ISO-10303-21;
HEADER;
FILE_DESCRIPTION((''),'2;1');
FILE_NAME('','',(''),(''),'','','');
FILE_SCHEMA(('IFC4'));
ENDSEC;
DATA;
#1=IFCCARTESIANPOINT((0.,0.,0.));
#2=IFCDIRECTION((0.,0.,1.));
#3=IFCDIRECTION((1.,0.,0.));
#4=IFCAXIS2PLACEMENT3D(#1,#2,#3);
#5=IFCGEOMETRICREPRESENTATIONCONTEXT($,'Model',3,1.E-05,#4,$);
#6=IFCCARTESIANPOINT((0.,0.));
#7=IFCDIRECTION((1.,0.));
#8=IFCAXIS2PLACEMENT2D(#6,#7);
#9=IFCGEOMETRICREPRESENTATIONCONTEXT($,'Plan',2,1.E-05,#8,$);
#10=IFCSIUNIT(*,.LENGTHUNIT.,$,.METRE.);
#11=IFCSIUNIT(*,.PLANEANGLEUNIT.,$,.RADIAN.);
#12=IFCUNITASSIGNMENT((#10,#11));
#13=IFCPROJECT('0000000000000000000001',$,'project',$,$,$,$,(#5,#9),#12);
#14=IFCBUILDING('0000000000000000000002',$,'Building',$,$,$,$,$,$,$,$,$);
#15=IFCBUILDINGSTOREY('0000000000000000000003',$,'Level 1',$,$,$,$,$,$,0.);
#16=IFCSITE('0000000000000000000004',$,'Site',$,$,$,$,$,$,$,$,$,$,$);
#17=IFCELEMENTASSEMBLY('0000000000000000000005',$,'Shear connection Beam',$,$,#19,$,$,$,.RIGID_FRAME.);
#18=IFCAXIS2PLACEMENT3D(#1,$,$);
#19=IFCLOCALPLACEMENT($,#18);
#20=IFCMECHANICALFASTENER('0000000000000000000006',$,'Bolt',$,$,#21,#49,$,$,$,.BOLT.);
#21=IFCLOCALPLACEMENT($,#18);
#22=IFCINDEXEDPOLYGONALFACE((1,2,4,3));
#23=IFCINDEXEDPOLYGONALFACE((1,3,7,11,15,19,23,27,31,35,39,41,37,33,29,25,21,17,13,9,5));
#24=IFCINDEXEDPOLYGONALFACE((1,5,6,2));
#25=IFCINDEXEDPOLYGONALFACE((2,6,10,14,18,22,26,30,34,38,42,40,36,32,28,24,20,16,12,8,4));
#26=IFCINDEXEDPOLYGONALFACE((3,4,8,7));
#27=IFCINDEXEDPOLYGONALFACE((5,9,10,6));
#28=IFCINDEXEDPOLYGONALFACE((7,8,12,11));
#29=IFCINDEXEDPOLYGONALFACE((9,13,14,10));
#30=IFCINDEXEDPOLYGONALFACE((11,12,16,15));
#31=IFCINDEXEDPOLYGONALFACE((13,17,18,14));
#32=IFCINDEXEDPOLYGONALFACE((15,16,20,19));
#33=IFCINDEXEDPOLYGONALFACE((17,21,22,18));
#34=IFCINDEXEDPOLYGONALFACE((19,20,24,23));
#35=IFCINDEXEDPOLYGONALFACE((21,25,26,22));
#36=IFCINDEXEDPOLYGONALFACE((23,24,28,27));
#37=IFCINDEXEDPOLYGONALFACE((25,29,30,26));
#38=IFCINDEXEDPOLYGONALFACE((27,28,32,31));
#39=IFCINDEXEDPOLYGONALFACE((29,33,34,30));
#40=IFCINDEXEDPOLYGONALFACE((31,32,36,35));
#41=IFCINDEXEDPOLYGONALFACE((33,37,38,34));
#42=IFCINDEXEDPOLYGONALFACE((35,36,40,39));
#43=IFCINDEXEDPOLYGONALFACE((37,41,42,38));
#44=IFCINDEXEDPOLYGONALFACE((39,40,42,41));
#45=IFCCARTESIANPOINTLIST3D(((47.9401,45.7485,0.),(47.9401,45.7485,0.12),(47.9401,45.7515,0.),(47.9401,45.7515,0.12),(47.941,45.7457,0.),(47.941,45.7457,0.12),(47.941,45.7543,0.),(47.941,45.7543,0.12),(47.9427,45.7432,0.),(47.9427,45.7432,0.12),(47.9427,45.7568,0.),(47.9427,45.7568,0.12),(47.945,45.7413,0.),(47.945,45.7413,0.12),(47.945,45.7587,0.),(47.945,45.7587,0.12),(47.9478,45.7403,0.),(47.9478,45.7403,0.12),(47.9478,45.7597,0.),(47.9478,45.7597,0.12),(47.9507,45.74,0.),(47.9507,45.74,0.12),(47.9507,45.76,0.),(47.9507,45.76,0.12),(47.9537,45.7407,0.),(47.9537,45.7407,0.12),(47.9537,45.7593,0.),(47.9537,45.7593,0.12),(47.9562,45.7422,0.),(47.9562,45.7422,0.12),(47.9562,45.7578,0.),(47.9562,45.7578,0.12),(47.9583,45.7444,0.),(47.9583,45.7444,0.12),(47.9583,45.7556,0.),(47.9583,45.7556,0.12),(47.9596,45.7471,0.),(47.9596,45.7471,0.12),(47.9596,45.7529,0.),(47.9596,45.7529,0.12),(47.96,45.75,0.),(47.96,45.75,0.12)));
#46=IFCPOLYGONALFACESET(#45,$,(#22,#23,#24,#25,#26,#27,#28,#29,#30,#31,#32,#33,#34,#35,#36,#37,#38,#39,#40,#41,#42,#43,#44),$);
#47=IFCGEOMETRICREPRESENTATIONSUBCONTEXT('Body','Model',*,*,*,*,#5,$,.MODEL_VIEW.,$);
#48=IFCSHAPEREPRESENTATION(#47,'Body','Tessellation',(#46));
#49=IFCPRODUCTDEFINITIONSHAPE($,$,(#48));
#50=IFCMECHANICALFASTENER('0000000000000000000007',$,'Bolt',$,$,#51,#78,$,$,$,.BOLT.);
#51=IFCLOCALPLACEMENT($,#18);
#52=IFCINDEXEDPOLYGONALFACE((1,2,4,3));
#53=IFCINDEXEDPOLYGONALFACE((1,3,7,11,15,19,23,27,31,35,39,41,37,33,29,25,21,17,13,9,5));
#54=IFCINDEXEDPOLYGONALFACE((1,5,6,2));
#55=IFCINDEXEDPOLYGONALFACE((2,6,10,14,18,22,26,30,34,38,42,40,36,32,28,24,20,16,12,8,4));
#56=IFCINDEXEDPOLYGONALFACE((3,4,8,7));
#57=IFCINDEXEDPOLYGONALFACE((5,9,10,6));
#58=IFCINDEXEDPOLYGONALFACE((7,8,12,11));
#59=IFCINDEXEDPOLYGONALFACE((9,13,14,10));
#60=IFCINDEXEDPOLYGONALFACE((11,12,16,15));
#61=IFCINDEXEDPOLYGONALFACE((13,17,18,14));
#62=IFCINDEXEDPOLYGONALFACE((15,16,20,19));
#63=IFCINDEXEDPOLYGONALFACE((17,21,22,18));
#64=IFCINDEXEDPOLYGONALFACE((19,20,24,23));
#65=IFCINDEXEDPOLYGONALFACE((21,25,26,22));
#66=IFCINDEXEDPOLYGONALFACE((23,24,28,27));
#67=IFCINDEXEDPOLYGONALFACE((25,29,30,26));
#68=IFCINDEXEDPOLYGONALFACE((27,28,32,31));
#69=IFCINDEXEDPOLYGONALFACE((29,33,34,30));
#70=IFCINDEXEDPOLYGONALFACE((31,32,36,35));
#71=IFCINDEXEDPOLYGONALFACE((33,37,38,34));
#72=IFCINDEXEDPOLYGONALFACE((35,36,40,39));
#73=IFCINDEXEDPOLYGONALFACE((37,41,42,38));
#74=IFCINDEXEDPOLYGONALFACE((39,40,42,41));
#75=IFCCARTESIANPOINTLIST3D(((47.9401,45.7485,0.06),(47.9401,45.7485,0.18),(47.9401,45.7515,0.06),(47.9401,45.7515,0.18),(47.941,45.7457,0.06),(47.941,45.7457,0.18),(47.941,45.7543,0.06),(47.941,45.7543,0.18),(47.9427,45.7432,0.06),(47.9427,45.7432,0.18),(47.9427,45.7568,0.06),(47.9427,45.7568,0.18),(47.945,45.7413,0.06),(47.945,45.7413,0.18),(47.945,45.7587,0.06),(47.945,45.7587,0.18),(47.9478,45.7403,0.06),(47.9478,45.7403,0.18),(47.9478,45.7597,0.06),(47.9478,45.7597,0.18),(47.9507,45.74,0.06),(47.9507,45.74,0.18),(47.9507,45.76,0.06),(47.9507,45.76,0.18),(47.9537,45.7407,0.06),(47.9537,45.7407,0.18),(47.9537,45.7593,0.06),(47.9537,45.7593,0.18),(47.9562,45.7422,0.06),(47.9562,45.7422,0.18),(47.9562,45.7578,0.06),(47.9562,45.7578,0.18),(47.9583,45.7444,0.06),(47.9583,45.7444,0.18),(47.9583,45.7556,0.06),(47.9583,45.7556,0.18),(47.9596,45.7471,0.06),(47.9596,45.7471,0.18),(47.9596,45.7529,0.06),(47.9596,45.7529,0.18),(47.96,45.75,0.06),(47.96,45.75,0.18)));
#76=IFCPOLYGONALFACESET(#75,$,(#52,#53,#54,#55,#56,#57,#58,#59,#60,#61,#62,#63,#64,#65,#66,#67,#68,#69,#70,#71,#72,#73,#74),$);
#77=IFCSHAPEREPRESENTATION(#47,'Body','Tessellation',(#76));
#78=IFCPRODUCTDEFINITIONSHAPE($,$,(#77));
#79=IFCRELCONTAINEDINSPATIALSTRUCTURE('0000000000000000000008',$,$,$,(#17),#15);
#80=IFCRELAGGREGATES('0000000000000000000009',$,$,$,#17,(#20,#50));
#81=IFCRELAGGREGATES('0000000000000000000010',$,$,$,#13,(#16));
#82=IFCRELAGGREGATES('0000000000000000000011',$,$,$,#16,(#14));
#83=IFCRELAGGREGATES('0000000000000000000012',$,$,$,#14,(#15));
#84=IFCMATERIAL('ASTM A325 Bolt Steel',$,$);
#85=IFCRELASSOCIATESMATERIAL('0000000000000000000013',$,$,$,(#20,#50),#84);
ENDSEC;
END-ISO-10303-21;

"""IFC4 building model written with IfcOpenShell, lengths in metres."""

from ifc_helpers import new_model, si_unit, frame, origin_with_axes, origin_2d, origin_2d_with_axis, place, context, subcontext, project, spatial, circle, extrude, material, element, aggregate, save


model = new_model("IFC4")

# Units and contexts
model_context = context("Model", 3, precision=1e-05, world=origin_with_axes())
plan_context = context("Plan", 2, precision=1e-05, world=origin_2d_with_axis())
body_context = subcontext(model_context, "Body", "Model", "MODEL_VIEW")
ifc_project = project(units=[si_unit("LENGTHUNIT", "METRE"), si_unit("PLANEANGLEUNIT", "RADIAN")], contexts=[model_context, plan_context])

# Site, building, storey
site = spatial("IfcSite", under=ifc_project, Name="Site")
building = spatial("IfcBuilding", under=site, Name="Building")
storey = spatial("IfcBuildingStorey", under=building, Name="Level 1", Elevation=0.0)

# Shared definitions
ifc_material_1 = material(Name="ASTM A325 Bolt Steel")

# Element assembly, mechanical fasteners
assembly_1 = element("IfcElementAssembly", 1, inside=storey, Name="Shear connection Beam", PredefinedType="RIGID_FRAME")
mechanical_fastener_1_placement = place(None, frame((47.95, 45.75, 0.0), z_axis=(0.0, 0.0, 1.0), x_axis=(1.0, 0.0, 0.0)))
mechanical_fastener_1 = element("IfcMechanicalFastener", 2, at=mechanical_fastener_1_placement, material=ifc_material_1, Name="Bolt", PredefinedType="BOLT", context=body_context, shape_type="SweptSolid", body=[
    extrude(circle(Radius=0.01, at=origin_2d()), origin_with_axes(), (0.0, 0.0, 1.0), 0.12),
])
mechanical_fastener_2_placement = place(None, frame((47.95, 45.75, 0.06), z_axis=(0.0, 0.0, 1.0), x_axis=(1.0, 0.0, 0.0)))
mechanical_fastener_2 = element("IfcMechanicalFastener", 3, at=mechanical_fastener_2_placement, material=ifc_material_1, Name="Bolt", PredefinedType="BOLT", context=body_context, shape_type="SweptSolid", body=[
    extrude(circle(Radius=0.01, at=origin_2d()), origin_with_axes(), (0.0, 0.0, 1.0), 0.12),
])
aggregate(assembly_1, [mechanical_fastener_1, mechanical_fastener_2])

save(model, "model.ifc")
